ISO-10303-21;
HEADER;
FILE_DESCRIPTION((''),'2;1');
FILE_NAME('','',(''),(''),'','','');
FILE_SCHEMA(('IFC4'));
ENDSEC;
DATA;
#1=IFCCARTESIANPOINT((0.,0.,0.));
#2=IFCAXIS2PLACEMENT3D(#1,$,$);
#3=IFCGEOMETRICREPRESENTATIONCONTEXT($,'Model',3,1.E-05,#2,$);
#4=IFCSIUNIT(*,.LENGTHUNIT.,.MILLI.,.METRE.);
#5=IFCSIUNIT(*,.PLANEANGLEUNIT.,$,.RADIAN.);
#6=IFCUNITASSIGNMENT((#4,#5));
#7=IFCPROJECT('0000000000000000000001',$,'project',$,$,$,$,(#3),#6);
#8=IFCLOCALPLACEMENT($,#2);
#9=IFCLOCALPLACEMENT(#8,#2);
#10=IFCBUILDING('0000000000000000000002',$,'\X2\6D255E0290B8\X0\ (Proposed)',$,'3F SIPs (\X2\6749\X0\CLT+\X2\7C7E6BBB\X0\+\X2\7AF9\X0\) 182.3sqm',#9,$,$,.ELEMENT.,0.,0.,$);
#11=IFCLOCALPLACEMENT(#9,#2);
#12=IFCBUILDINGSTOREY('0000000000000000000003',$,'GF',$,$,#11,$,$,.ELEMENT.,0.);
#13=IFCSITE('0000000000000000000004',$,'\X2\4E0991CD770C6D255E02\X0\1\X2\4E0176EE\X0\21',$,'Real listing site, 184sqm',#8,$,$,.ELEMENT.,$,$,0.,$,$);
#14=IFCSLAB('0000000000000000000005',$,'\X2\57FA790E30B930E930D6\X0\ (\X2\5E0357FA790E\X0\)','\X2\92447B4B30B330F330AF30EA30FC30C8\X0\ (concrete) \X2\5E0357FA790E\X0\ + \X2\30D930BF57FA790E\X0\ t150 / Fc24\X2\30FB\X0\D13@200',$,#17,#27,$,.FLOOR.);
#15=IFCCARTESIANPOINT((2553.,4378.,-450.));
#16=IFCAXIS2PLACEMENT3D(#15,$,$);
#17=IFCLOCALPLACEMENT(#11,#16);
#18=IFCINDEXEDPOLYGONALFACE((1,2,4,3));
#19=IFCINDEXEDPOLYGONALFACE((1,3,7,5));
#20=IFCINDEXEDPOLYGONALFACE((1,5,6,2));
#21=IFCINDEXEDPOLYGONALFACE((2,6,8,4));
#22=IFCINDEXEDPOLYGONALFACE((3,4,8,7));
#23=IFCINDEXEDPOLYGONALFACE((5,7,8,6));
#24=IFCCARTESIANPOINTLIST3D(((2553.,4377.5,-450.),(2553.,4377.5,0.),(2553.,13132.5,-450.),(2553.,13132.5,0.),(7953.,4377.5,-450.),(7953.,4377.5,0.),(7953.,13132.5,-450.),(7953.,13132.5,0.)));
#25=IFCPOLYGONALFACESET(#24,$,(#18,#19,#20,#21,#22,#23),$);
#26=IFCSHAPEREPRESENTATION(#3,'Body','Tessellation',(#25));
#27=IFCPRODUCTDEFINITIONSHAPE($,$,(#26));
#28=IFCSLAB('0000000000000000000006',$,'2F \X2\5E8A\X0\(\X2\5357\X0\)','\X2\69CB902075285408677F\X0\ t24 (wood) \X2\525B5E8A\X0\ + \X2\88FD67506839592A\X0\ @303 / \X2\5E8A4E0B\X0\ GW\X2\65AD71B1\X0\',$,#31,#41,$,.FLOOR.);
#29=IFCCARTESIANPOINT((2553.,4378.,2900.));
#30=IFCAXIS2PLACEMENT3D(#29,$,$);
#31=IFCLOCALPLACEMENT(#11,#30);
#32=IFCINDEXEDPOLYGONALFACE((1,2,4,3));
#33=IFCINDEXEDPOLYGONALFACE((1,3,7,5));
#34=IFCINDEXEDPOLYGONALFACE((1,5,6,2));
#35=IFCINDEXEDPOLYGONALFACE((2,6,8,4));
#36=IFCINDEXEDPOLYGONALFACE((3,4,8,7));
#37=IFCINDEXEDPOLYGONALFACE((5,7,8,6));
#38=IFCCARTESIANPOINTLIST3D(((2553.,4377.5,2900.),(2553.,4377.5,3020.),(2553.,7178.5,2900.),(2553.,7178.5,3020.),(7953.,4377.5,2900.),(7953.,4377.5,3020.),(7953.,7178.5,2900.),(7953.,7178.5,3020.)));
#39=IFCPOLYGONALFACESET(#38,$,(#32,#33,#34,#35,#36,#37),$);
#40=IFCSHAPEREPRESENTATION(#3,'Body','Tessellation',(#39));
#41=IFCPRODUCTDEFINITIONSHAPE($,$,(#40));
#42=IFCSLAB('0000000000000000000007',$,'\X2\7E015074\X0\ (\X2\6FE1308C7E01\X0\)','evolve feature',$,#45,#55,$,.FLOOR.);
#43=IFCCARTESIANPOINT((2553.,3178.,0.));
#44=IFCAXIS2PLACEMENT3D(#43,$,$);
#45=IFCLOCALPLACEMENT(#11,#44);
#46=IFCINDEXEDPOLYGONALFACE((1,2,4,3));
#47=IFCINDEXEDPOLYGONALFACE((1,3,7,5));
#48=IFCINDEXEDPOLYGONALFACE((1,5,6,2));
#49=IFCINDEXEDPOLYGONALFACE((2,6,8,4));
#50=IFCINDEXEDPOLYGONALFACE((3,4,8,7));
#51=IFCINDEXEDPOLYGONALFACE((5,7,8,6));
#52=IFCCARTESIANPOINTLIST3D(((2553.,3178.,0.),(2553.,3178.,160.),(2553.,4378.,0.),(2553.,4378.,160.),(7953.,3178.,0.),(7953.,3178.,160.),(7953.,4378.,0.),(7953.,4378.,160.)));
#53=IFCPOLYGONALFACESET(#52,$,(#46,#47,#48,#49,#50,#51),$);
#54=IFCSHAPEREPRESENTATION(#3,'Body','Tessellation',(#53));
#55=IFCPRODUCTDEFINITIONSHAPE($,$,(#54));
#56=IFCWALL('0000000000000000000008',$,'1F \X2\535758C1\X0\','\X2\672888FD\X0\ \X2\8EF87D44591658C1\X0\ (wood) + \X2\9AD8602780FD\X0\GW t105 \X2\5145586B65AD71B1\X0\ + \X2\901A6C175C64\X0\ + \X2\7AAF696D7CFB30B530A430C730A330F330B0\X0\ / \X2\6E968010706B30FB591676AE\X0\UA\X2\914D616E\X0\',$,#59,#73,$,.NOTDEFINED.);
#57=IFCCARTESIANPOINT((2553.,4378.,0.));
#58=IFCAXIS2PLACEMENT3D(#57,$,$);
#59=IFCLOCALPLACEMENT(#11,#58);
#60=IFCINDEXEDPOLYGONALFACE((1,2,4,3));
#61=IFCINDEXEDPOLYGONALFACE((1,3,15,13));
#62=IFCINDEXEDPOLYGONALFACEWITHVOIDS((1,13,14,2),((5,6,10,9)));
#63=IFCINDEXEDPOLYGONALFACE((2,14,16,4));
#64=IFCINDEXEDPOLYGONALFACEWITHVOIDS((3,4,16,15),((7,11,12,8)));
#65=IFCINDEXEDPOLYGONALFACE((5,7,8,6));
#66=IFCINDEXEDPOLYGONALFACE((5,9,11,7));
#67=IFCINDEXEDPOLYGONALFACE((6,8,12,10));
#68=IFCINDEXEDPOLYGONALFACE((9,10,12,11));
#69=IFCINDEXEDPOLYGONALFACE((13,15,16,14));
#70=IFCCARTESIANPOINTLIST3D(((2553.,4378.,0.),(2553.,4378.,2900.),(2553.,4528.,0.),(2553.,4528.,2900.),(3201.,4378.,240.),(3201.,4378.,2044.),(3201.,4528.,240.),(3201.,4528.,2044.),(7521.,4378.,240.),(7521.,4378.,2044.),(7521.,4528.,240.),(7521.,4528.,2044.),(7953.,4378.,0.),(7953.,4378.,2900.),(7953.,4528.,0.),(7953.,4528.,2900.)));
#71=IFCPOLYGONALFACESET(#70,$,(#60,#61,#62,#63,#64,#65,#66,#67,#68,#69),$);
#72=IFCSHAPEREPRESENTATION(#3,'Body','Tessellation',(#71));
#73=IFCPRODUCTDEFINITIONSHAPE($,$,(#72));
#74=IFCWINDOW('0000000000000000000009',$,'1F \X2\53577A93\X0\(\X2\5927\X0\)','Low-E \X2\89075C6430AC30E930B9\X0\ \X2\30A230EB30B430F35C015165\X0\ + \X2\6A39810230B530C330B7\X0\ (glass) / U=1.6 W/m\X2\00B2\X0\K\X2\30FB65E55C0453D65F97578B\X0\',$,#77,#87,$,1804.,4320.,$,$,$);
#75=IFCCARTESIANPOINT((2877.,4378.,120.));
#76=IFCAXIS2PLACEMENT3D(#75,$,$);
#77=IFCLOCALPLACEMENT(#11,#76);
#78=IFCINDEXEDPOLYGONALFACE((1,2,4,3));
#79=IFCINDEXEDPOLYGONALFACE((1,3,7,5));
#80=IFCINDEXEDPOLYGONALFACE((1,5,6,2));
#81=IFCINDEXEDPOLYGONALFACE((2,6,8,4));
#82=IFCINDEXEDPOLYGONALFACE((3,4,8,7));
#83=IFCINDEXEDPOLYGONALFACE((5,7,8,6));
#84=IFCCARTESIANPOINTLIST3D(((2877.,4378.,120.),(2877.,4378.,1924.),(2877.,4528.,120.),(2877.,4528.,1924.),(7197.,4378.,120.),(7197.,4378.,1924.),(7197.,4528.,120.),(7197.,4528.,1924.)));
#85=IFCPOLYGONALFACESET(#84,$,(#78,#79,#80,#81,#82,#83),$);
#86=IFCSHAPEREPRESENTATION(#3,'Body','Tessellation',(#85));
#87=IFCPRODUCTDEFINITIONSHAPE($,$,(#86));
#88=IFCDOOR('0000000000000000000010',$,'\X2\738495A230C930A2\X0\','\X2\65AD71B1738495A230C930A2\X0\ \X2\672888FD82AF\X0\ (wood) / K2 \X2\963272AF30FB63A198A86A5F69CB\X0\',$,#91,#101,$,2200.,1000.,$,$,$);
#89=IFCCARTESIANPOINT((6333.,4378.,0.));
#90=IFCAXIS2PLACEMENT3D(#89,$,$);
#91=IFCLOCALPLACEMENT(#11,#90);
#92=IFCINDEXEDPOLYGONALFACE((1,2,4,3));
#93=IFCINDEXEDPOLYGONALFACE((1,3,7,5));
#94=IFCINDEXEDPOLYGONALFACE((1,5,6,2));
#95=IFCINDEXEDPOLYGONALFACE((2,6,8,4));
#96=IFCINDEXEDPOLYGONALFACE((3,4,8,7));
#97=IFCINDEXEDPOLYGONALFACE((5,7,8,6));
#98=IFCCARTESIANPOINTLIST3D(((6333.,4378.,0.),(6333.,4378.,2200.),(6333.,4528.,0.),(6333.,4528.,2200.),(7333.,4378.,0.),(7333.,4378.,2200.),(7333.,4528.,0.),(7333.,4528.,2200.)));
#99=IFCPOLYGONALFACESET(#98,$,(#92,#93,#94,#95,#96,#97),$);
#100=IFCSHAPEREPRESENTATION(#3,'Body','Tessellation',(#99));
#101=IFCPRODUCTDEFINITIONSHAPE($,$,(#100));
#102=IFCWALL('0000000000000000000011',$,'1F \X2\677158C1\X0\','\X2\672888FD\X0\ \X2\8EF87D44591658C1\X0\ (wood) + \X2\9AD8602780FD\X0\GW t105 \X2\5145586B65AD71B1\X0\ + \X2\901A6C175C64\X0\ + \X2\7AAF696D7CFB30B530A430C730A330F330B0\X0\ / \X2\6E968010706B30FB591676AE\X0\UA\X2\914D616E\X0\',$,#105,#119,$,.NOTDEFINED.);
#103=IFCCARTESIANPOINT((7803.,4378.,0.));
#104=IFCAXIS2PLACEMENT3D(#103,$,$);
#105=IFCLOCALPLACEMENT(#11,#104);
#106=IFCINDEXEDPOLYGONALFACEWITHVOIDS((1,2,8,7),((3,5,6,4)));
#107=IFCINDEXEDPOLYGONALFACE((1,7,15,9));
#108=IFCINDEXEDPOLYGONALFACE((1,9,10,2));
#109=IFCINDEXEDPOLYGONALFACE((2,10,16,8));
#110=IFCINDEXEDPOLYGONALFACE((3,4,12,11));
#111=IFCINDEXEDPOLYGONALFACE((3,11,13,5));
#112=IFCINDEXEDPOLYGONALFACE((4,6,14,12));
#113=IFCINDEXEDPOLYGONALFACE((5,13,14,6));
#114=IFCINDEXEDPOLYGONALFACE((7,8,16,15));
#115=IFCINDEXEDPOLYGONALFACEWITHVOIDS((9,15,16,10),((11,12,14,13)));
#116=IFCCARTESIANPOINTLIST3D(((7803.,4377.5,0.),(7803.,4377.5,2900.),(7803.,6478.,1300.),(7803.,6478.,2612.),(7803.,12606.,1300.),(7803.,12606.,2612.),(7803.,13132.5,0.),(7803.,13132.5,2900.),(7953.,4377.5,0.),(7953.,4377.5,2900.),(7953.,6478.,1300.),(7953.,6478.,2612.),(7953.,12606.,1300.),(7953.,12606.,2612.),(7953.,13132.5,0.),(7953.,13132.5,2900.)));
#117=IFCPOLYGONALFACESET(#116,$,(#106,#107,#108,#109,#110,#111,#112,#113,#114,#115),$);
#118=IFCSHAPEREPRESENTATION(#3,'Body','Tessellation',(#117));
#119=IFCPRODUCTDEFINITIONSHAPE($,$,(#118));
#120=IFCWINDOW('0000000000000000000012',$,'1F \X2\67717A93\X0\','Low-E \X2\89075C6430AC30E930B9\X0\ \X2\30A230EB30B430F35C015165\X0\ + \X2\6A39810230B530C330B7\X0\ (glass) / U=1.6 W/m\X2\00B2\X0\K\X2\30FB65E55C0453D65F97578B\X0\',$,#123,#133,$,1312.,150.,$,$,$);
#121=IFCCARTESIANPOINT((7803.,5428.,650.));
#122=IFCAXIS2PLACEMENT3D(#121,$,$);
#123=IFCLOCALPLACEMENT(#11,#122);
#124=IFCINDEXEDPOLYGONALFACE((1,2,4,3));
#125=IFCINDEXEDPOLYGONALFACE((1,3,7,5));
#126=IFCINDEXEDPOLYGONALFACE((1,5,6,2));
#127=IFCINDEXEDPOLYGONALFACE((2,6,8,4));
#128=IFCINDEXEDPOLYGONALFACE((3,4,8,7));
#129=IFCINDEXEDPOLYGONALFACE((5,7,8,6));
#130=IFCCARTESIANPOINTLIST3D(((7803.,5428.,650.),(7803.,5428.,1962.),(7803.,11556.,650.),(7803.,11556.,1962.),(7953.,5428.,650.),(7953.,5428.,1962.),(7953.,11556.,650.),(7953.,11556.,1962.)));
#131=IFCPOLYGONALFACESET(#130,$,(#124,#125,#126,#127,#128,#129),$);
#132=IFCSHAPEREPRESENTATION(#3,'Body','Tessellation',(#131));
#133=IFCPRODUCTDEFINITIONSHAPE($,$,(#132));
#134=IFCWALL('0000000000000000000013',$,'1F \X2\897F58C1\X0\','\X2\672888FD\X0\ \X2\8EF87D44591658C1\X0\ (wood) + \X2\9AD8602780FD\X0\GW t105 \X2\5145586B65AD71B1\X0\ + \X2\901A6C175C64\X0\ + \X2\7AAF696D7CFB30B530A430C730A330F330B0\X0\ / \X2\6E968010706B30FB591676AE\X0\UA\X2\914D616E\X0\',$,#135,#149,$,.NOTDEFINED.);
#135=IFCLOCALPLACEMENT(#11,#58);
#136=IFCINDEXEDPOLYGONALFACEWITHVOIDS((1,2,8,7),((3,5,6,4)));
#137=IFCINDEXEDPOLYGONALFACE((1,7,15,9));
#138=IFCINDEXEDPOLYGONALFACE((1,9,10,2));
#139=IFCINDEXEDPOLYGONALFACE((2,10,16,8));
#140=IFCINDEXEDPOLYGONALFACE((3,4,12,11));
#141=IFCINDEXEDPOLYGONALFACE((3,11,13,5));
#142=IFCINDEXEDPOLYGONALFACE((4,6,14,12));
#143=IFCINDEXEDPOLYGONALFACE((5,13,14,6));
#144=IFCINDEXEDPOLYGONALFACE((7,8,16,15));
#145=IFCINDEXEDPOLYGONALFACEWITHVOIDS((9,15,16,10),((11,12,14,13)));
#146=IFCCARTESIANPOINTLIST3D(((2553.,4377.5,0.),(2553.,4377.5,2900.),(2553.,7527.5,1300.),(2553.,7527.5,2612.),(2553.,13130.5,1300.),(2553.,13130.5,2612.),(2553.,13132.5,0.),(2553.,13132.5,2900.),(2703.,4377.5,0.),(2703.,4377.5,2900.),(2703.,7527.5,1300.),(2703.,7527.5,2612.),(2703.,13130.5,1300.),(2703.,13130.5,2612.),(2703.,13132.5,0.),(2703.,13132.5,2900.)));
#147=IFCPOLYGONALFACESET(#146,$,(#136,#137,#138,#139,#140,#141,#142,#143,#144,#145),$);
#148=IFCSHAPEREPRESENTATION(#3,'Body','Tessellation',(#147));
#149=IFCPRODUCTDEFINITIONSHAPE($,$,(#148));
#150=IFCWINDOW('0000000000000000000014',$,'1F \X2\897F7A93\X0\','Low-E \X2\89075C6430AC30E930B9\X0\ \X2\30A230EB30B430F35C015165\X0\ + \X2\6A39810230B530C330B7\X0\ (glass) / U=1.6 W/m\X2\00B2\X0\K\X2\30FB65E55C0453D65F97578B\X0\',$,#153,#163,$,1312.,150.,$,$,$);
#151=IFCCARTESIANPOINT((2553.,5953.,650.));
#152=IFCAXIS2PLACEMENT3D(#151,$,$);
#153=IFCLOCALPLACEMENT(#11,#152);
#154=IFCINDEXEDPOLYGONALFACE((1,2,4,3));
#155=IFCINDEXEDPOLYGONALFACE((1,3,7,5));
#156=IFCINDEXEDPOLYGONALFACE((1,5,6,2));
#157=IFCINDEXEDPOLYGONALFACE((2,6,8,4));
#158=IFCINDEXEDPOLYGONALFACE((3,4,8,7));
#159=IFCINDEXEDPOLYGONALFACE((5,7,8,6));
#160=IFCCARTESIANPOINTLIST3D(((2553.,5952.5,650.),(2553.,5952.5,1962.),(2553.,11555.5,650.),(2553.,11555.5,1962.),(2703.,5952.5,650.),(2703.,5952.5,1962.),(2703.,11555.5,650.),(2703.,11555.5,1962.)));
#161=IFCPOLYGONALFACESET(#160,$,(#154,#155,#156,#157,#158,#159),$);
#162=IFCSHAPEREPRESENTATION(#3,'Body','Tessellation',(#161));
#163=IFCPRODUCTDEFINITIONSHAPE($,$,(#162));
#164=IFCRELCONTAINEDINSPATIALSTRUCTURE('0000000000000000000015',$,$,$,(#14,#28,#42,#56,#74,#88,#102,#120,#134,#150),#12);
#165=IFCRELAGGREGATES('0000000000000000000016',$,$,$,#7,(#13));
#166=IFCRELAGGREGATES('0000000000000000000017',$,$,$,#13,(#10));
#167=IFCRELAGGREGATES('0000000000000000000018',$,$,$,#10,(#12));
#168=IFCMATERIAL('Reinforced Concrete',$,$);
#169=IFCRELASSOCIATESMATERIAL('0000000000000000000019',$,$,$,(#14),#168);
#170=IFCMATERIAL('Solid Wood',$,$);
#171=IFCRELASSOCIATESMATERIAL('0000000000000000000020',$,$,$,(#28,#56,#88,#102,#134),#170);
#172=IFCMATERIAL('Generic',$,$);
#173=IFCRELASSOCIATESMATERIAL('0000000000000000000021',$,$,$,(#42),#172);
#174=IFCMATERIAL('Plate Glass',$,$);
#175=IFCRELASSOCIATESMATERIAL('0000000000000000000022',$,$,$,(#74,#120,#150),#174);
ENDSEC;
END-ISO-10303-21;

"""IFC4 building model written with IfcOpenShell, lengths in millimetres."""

from ifc_helpers import new_model, si_unit, frame, frame_2d, origin, place, context, project, spatial, rectangle, extrude, material, element, fill, save


model = new_model("IFC4")

# Units and contexts
model_context = context("Model", 3, precision=1e-05, world=origin())
ifc_project = project(units=[si_unit("LENGTHUNIT", "METRE", prefix="MILLI"), si_unit("PLANEANGLEUNIT", "RADIAN")], contexts=[model_context])

# Site, building, storey
site_placement = place(None, origin())
site = spatial("IfcSite", under=ifc_project, at=site_placement, Name="三重県津市1丁目21", ObjectType="Real listing site, 184sqm", CompositionType="ELEMENT", RefElevation=0.0)
building_placement = place(site_placement, origin())
building = spatial("IfcBuilding", under=site, at=building_placement, Name="津市邸 (Proposed)", ObjectType="3F SIPs (杉CLT+籾殻+竹) 182.3sqm", CompositionType="ELEMENT", ElevationOfRefHeight=0.0, ElevationOfTerrain=0.0)
storey_placement = place(building_placement, origin())
storey = spatial("IfcBuildingStorey", under=building, at=storey_placement, Name="GF", CompositionType="ELEMENT", Elevation=0.0)

# Slabs
ifc_material_1 = material(Name="Reinforced Concrete")
slab_1_placement = place(storey_placement, frame((2553.0, 4378.0, -450.0)))
element("IfcSlab", 1, at=slab_1_placement, inside=storey, material=ifc_material_1, Name="基礎スラブ (布基礎)", Description="鉄筋コンクリート (concrete) 布基礎 + ベタ基礎 t150 / Fc24・D13@200", PredefinedType="FLOOR", context=model_context, shape_type="SweptSolid", body=[
    extrude(rectangle(XDim=5400.0, YDim=8755.0, at=frame_2d((2700.0, 4377.0))), frame((2553.0, 4378.0, -450.0)), (0.0, 0.0, 1.0), 450.0),
])
ifc_material_2 = material(Name="Solid Wood")
slab_2_placement = place(storey_placement, frame((2553.0, 4378.0, 2900.0)))
element("IfcSlab", 2, at=slab_2_placement, inside=storey, material=ifc_material_2, Name="2F 床(南)", Description="構造用合板 t24 (wood) 剛床 + 製材根太 @303 / 床下 GW断熱", PredefinedType="FLOOR", context=model_context, shape_type="SweptSolid", body=[
    extrude(rectangle(XDim=5400.0, YDim=2801.0, at=frame_2d((2700.0, 1400.0))), frame((2553.0, 4378.0, 2900.0)), (0.0, 0.0, 1.0), 120.0),
])
ifc_material_3 = material(Name="Generic")
slab_3_placement = place(storey_placement, frame((2553.0, 3178.0, 0.0)))
element("IfcSlab", 3, at=slab_3_placement, inside=storey, material=ifc_material_3, Name="縁側 (濡れ縁)", Description="evolve feature", PredefinedType="FLOOR", context=model_context, shape_type="SweptSolid", body=[
    extrude(rectangle(XDim=5400.0, YDim=1200.0, at=frame_2d((2700.0, 600.0))), frame((2553.0, 3178.0, 0.0)), (0.0, 0.0, 1.0), 160.0),
])

# Wall, openings, window, door
wall_1_placement = place(storey_placement, frame((2553.0, 4378.0, 0.0)))
wall_1 = element("IfcWall", 4, at=wall_1_placement, inside=storey, material=ifc_material_2, Name="1F 南壁", Description="木製 軸組外壁 (wood) + 高性能GW t105 充填断熱 + 通気層 + 窯業系サイディング / 準耐火・外皮UA配慮", PredefinedType="NOTDEFINED", context=model_context, shape_type="SweptSolid", body=[
    extrude(rectangle(XDim=5400.0, YDim=150.0, at=frame_2d((2700.0, 75.0))), frame((2553.0, 4378.0, 0.0)), (0.0, 0.0, 1.0), 2900.0),
])
opening_1_placement = place(storey_placement, frame((2877.0, 4378.0, 120.0)))
opening_1 = element("IfcOpeningElement", 5, at=opening_1_placement, cuts=wall_1, PredefinedType="NOTDEFINED", context=model_context, shape_type="SweptSolid", body=[
    extrude(rectangle(XDim=4320.0, YDim=150.0, at=frame_2d((2160.0, 75.0))), frame((2877.0, 4378.0, 120.0)), (0.0, 0.0, 1.0), 1804.0),
])
opening_2_placement = place(storey_placement, frame((6333.0, 4378.0, 0.0)))
opening_2 = element("IfcOpeningElement", 6, at=opening_2_placement, cuts=wall_1, PredefinedType="NOTDEFINED", context=model_context, shape_type="SweptSolid", body=[
    extrude(rectangle(XDim=1000.0, YDim=150.0, at=frame_2d((500.0, 75.0))), frame((6333.0, 4378.0, 0.0)), (0.0, 0.0, 1.0), 2200.0),
])
ifc_material_4 = material(Name="Plate Glass")
window_1_placement = place(storey_placement, frame((2877.0, 4378.0, 120.0)))
window_1 = element("IfcWindow", 7, at=window_1_placement, inside=storey, material=ifc_material_4, Name="1F 南窓(大)", Description="Low-E 複層ガラス アルゴン封入 + 樹脂サッシ (glass) / U=1.6 W/m²K・日射取得型", OverallHeight=1804.0, OverallWidth=4320.0, context=model_context, shape_type="SweptSolid", body=[
    extrude(rectangle(XDim=4320.0, YDim=150.0, at=frame_2d((2160.0, 75.0))), frame((2877.0, 4378.0, 120.0)), (0.0, 0.0, 1.0), 1804.0),
])
fill(opening_1, window_1)
door_placement = place(storey_placement, frame((6333.0, 4378.0, 0.0)))
door = element("IfcDoor", 8, at=door_placement, inside=storey, material=ifc_material_2, Name="玄関ドア", Description="断熱玄関ドア 木製芯 (wood) / K2 防犯・採風機構", OverallHeight=2200.0, OverallWidth=1000.0, context=model_context, shape_type="SweptSolid", body=[
    extrude(rectangle(XDim=1000.0, YDim=150.0, at=frame_2d((500.0, 75.0))), frame((6333.0, 4378.0, 0.0)), (0.0, 0.0, 1.0), 2200.0),
])
fill(opening_2, door)

# Walls, openings, windows
wall_2_placement = place(storey_placement, frame((7803.0, 4378.0, 0.0)))
wall_2 = element("IfcWall", 9, at=wall_2_placement, inside=storey, material=ifc_material_2, Name="1F 東壁", Description="木製 軸組外壁 (wood) + 高性能GW t105 充填断熱 + 通気層 + 窯業系サイディング / 準耐火・外皮UA配慮", PredefinedType="NOTDEFINED", context=model_context, shape_type="SweptSolid", body=[
    extrude(rectangle(XDim=150.0, YDim=8755.0, at=frame_2d((75.0, 4377.0))), frame((7803.0, 4378.0, 0.0)), (0.0, 0.0, 1.0), 2900.0),
])
opening_3_placement = place(storey_placement, frame((7803.0, 5428.0, 650.0)))
opening_3 = element("IfcOpeningElement", 10, at=opening_3_placement, cuts=wall_2, PredefinedType="NOTDEFINED", context=model_context, shape_type="SweptSolid", body=[
    extrude(rectangle(XDim=150.0, YDim=6128.0, at=frame_2d((75.0, 3064.0))), frame((7803.0, 5428.0, 650.0)), (0.0, 0.0, 1.0), 1312.0),
])
window_2_placement = place(storey_placement, frame((7803.0, 5428.0, 650.0)))
window_2 = element("IfcWindow", 11, at=window_2_placement, inside=storey, material=ifc_material_4, Name="1F 東窓", Description="Low-E 複層ガラス アルゴン封入 + 樹脂サッシ (glass) / U=1.6 W/m²K・日射取得型", OverallHeight=1312.0, OverallWidth=150.0, context=model_context, shape_type="SweptSolid", body=[
    extrude(rectangle(XDim=150.0, YDim=6128.0, at=frame_2d((75.0, 3064.0))), frame((7803.0, 5428.0, 650.0)), (0.0, 0.0, 1.0), 1312.0),
])
fill(opening_3, window_2)
wall_3_placement = place(storey_placement, frame((2553.0, 4378.0, 0.0)))
wall_3 = element("IfcWall", 12, at=wall_3_placement, inside=storey, material=ifc_material_2, Name="1F 西壁", Description="木製 軸組外壁 (wood) + 高性能GW t105 充填断熱 + 通気層 + 窯業系サイディング / 準耐火・外皮UA配慮", PredefinedType="NOTDEFINED", context=model_context, shape_type="SweptSolid", body=[
    extrude(rectangle(XDim=150.0, YDim=8755.0, at=frame_2d((75.0, 4377.0))), frame((2553.0, 4378.0, 0.0)), (0.0, 0.0, 1.0), 2900.0),
])
opening_4_placement = place(storey_placement, frame((2553.0, 5953.0, 650.0)))
opening_4 = element("IfcOpeningElement", 13, at=opening_4_placement, cuts=wall_3, PredefinedType="NOTDEFINED", context=model_context, shape_type="SweptSolid", body=[
    extrude(rectangle(XDim=150.0, YDim=5603.0, at=frame_2d((75.0, 2801.0))), frame((2553.0, 5953.0, 650.0)), (0.0, 0.0, 1.0), 1312.0),
])
window_3_placement = place(storey_placement, frame((2553.0, 5953.0, 650.0)))
window_3 = element("IfcWindow", 14, at=window_3_placement, inside=storey, material=ifc_material_4, Name="1F 西窓", Description="Low-E 複層ガラス アルゴン封入 + 樹脂サッシ (glass) / U=1.6 W/m²K・日射取得型", OverallHeight=1312.0, OverallWidth=150.0, context=model_context, shape_type="SweptSolid", body=[
    extrude(rectangle(XDim=150.0, YDim=5603.0, at=frame_2d((75.0, 2801.0))), frame((2553.0, 5953.0, 650.0)), (0.0, 0.0, 1.0), 1312.0),
])
fill(opening_4, window_3)

save(model, "model.ifc")
